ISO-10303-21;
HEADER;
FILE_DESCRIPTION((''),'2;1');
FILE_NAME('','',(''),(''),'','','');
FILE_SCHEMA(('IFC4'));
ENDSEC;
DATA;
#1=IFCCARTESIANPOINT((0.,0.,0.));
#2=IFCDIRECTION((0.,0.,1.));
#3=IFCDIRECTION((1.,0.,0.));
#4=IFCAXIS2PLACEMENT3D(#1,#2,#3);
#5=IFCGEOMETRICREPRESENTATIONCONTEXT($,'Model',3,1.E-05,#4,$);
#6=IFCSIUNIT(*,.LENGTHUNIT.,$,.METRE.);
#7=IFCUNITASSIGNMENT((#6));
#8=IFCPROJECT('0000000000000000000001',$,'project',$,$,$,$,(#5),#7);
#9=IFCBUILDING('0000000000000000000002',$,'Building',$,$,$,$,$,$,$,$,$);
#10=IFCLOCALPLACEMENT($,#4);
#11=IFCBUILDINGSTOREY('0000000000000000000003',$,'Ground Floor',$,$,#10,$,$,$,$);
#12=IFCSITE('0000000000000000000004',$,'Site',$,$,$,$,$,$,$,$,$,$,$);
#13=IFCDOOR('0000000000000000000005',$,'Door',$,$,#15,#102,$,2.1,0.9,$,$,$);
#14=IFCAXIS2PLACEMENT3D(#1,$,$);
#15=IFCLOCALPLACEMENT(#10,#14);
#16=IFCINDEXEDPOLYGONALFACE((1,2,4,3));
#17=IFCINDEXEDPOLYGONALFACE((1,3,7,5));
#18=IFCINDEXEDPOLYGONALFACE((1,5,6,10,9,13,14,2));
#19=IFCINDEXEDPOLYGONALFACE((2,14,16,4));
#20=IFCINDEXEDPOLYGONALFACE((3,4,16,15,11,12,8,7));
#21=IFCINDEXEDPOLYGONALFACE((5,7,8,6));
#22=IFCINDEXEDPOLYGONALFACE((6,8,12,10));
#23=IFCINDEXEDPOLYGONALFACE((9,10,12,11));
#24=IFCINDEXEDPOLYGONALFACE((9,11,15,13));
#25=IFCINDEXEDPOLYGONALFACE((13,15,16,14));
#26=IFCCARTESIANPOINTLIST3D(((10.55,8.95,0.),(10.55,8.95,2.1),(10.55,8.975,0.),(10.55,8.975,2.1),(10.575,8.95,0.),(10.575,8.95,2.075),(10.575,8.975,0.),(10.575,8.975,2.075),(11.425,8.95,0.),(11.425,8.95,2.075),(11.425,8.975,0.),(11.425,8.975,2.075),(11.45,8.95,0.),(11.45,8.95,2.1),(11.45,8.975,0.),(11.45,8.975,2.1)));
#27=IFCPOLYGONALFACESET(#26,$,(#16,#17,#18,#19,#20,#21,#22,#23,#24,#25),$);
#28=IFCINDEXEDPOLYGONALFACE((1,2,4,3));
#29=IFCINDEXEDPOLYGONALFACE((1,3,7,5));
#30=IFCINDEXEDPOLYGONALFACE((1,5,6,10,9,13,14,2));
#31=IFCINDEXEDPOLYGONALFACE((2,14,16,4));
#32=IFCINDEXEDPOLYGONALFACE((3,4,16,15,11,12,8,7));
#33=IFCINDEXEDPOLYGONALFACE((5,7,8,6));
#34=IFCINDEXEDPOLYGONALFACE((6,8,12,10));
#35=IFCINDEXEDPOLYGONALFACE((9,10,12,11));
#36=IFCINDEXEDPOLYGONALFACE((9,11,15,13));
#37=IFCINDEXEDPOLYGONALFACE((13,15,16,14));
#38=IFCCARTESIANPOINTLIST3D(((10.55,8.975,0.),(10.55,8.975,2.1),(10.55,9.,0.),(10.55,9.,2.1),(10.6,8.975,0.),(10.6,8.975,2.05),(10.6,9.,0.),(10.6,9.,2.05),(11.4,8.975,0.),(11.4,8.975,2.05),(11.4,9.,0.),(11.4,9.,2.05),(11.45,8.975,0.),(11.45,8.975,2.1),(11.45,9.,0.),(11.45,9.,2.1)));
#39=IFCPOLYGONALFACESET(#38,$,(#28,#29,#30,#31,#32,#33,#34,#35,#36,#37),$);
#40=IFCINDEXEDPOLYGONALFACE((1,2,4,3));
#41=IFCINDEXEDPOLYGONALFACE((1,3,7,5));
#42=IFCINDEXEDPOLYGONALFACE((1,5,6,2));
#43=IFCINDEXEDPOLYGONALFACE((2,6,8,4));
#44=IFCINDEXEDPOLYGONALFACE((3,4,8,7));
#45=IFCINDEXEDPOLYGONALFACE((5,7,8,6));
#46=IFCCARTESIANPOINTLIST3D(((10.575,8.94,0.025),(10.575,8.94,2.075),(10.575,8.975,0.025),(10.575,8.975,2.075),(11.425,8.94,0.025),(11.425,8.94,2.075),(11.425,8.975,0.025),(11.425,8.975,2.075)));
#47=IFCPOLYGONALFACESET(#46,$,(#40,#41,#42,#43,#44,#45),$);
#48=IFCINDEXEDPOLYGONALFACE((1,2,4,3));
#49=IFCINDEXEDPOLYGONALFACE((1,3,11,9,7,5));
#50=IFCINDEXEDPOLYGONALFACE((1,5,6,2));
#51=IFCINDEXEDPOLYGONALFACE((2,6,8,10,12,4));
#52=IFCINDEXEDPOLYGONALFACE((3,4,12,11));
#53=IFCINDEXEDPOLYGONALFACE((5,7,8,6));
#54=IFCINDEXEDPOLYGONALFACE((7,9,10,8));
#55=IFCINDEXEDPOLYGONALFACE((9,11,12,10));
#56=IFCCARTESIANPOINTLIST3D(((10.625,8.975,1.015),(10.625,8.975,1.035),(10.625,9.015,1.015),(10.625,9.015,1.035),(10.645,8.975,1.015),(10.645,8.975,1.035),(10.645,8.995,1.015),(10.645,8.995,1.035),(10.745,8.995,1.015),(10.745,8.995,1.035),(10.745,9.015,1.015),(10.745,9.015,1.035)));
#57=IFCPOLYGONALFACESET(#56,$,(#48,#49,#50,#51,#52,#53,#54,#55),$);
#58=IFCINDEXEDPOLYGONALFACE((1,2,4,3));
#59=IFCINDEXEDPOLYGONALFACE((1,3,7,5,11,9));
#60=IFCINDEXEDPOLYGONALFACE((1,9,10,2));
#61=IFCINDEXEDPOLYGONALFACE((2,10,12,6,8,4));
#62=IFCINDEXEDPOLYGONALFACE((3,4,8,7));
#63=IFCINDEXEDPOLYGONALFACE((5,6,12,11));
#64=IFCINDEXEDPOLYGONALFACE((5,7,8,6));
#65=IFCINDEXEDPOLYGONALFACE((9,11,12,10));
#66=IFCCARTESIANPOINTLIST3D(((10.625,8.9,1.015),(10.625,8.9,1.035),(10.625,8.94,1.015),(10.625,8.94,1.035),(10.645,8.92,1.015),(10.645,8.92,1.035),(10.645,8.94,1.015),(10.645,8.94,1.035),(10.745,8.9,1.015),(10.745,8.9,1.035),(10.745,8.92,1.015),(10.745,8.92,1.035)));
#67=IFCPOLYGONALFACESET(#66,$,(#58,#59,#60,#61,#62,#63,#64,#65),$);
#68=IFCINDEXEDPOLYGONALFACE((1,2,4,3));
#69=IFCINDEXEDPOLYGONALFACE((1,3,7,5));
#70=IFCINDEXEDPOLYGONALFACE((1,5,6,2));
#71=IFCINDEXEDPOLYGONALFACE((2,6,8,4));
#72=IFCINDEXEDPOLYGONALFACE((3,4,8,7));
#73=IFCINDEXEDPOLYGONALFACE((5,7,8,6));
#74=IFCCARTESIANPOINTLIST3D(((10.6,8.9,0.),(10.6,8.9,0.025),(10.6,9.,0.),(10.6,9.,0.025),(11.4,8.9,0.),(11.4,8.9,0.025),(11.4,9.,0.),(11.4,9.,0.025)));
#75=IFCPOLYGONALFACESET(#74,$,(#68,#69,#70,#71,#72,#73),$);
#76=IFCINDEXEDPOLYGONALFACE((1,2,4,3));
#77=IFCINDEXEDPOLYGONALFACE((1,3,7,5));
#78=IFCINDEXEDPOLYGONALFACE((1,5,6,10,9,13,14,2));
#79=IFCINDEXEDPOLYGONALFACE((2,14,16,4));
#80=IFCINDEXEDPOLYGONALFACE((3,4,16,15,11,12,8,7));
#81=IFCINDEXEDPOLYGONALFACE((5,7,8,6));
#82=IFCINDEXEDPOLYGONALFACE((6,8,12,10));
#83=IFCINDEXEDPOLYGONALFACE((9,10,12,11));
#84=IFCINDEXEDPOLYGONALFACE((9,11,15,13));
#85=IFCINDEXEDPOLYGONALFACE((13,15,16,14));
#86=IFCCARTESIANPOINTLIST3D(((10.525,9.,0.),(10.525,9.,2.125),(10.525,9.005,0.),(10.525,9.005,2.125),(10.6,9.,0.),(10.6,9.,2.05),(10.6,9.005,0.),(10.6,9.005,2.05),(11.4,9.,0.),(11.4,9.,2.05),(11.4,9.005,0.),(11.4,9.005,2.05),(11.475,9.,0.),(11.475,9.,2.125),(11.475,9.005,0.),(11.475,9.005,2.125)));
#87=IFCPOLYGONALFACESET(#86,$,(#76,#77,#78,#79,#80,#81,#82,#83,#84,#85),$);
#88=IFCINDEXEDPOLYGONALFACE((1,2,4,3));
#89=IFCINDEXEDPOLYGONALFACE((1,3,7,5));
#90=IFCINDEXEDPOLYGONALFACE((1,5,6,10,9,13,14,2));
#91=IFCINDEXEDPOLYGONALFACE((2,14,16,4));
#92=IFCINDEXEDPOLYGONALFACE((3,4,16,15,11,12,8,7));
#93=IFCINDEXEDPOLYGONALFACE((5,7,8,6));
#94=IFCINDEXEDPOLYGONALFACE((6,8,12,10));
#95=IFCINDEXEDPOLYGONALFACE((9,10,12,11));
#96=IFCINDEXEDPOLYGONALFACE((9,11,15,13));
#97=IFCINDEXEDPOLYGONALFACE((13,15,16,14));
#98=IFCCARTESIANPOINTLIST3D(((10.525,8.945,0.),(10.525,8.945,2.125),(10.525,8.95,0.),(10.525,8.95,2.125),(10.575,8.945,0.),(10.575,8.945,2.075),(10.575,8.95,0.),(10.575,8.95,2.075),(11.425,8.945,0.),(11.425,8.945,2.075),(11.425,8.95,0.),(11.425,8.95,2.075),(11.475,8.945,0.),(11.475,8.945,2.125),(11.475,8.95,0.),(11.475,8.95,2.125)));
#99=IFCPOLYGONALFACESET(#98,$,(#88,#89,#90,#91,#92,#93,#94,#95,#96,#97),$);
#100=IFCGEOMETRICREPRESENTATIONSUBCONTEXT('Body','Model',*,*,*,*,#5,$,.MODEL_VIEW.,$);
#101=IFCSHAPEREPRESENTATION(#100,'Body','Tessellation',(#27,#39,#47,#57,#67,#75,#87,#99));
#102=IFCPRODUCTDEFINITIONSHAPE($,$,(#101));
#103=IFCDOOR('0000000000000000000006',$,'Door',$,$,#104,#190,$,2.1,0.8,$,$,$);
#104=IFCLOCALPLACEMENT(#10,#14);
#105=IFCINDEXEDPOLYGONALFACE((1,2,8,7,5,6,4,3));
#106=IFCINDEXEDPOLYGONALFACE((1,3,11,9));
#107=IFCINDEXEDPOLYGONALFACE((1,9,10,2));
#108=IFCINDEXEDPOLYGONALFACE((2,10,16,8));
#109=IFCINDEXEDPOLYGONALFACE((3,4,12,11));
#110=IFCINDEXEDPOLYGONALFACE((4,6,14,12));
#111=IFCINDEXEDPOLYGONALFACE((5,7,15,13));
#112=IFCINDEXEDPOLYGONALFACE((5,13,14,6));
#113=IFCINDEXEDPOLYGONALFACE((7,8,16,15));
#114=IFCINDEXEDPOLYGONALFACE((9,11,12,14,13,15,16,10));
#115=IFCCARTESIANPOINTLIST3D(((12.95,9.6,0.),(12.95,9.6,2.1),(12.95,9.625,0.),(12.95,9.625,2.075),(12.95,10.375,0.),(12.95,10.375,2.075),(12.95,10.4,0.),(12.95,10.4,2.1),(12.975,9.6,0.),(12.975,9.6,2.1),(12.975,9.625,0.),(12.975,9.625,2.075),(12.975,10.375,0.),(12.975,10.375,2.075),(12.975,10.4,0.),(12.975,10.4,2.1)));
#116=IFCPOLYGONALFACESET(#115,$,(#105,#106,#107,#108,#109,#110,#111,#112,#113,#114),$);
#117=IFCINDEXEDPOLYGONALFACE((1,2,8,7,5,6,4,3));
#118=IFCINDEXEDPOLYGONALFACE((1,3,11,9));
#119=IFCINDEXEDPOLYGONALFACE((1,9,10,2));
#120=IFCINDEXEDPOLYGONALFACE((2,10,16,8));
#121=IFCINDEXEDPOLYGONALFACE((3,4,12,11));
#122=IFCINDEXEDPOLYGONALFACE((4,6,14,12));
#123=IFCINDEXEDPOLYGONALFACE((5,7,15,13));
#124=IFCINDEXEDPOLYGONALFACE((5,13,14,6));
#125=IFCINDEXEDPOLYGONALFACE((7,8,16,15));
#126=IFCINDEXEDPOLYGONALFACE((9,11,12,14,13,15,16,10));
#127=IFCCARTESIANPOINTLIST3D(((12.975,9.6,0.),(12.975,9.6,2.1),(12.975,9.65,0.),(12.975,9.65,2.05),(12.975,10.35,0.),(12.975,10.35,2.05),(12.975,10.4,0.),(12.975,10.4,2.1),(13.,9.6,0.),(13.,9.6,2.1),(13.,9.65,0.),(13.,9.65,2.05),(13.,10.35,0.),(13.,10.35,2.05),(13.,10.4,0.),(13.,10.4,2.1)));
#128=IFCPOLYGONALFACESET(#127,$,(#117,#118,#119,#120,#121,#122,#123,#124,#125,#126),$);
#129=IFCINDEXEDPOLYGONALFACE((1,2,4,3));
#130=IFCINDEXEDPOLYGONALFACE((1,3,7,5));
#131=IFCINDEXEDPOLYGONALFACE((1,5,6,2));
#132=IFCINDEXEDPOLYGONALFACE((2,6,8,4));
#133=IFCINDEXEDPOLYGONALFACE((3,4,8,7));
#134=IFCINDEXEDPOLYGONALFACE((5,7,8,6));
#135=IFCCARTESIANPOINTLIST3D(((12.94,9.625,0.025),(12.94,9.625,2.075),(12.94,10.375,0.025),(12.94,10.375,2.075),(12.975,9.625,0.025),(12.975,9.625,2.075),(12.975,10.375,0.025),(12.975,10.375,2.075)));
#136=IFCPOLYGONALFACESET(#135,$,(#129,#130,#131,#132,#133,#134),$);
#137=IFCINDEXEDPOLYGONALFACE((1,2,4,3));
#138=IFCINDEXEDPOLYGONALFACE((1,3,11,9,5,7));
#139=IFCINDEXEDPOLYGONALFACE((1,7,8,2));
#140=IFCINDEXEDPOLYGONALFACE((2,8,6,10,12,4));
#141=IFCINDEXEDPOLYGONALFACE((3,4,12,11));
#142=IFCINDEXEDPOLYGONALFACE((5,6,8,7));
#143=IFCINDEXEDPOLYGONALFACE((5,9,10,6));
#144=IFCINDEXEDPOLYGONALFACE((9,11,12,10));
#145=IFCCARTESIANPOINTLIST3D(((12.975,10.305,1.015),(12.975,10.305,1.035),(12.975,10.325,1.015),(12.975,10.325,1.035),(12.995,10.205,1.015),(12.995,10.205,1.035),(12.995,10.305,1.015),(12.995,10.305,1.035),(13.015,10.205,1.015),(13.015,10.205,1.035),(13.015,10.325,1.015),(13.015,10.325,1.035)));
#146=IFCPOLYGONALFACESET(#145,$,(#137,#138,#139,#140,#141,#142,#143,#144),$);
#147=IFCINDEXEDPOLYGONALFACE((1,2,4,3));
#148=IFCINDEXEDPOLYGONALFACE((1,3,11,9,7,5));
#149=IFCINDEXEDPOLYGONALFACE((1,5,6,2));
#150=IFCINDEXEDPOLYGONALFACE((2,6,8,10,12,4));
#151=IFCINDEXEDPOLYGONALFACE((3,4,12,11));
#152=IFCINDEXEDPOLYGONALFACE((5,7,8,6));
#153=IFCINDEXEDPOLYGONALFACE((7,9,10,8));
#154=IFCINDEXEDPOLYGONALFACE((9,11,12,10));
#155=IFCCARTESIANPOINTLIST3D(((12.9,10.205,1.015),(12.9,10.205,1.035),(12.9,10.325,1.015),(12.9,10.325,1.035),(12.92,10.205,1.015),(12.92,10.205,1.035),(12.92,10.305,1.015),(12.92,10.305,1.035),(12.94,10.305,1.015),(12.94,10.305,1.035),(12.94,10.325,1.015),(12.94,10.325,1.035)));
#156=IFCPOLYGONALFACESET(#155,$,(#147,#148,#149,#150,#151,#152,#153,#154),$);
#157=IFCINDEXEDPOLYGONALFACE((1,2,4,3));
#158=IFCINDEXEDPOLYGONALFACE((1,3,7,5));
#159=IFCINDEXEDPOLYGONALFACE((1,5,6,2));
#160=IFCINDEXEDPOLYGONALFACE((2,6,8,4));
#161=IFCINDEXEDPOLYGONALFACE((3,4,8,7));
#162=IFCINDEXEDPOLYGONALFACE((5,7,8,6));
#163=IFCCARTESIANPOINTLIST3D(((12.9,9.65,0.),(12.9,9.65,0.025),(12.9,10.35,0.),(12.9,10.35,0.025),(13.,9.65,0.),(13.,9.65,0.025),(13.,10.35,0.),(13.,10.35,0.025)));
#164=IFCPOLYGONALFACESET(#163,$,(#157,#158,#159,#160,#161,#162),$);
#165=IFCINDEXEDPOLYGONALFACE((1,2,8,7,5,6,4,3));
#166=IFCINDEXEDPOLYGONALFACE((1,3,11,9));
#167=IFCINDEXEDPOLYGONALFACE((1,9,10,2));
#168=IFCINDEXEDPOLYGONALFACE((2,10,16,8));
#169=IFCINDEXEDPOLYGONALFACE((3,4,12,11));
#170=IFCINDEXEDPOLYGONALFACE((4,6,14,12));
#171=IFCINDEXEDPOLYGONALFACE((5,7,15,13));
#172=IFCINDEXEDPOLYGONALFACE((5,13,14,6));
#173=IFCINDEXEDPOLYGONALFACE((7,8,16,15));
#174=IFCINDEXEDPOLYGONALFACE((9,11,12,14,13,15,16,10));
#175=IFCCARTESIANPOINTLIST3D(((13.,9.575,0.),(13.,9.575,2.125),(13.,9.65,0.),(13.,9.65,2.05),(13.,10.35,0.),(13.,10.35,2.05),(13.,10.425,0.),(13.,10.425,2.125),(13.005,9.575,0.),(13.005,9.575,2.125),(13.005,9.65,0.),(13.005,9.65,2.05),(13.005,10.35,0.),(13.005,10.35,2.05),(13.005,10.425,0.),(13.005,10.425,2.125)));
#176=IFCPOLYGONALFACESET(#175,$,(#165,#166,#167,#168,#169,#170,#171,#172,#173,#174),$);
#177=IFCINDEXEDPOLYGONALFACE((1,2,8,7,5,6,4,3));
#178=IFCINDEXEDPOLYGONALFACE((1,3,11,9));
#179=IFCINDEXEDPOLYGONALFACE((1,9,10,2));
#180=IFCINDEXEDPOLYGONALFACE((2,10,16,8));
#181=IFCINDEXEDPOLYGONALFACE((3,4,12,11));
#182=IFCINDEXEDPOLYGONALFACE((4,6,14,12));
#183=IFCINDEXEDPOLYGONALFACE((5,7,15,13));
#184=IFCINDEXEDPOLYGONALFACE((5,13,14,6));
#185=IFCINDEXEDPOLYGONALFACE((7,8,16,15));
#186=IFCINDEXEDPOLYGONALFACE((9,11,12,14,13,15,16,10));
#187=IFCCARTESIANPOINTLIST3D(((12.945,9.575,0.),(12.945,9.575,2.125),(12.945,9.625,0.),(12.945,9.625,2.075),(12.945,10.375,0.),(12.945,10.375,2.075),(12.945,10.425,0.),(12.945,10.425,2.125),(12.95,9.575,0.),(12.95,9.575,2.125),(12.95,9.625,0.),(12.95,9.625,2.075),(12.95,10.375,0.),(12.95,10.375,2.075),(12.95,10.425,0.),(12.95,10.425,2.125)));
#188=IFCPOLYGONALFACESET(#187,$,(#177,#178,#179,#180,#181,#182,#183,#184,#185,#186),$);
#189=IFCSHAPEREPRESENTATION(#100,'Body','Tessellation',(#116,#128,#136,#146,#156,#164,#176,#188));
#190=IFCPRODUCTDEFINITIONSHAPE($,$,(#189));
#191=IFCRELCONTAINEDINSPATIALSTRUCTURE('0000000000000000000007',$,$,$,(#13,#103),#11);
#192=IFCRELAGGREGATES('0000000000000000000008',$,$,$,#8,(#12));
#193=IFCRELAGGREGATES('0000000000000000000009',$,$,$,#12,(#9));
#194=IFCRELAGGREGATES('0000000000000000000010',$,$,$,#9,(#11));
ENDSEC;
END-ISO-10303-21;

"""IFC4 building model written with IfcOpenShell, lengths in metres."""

from ifc_helpers import new_model, si_unit, frame, origin_with_axes, place, context, subcontext, project, spatial, line, indexed_curve, outline, extrude, element, save


model = new_model("IFC4")

# Units and contexts
model_context = context("Model", 3, precision=1e-05, world=origin_with_axes())
body_context = subcontext(model_context, "Body", "Model", "MODEL_VIEW")
ifc_project = project(units=[si_unit("LENGTHUNIT", "METRE")], contexts=[model_context])

# Site, building, storey
site = spatial("IfcSite", under=ifc_project, Name="Site")
building = spatial("IfcBuilding", under=site, Name="Building")
storey_placement = place(None, origin_with_axes())
storey = spatial("IfcBuildingStorey", under=building, at=storey_placement, Name="Ground Floor")

# Doors
door_1_placement = place(storey_placement, frame((11.45, 9.0, 0.0), z_axis=(0.0, 0.0, 1.0), x_axis=(-1.0, 0.0, 0.0)))
element("IfcDoor", 1, at=door_1_placement, inside=storey, Name="Door", OverallHeight=2.1, OverallWidth=0.9, context=body_context, shape_type="SweptSolid", body=[
    extrude(outline(indexed_curve([(0.0, 0.0), (0.0, 2.1), (0.9, 2.1), (0.9, 0.0), (0.875, 0.0), (0.875, 2.075), (0.025, 2.075), (0.025, 0.0)], segments=[line(1, 2, 3, 4, 5, 6, 7, 8, 1)])), frame((0.0, 0.025, 0.0), z_axis=(0.0, -1.0, 0.0), x_axis=(1.0, 0.0, 0.0)), (0.0, 0.0, -1.0), 0.025),
    extrude(outline(indexed_curve([(0.0, 0.0), (0.0, 2.1), (0.9, 2.1), (0.9, 0.0), (0.85, 0.0), (0.85, 2.05), (0.05, 2.05), (0.05, 0.0)], segments=[line(1, 2, 3, 4, 5, 6, 7, 8, 1)])), frame((0.0, 0.0, 0.0), z_axis=(0.0, -1.0, 0.0), x_axis=(1.0, 0.0, 0.0)), (0.0, 0.0, -1.0), 0.025),
    extrude(outline(indexed_curve([(0.0, 0.0), (0.85, 0.0), (0.85, 0.035), (0.0, 0.035)], segments=[line(1, 2, 3, 4, 1)])), frame((0.025, 0.025, 0.025), z_axis=(0.0, 0.0, 1.0), x_axis=(1.0, 0.0, 0.0)), (0.0, 0.0, 1.0), 2.05),
    extrude(outline(indexed_curve([(0.0, 0.0), (0.0, -0.04), (-0.12, -0.04), (-0.12, -0.02), (-0.02, -0.02), (-0.02, 0.0)], segments=[line(1, 2, 3, 4, 5, 6, 1)])), frame((0.825, 0.025, 1.015), z_axis=(0.0, 0.0, 1.0), x_axis=(1.0, 0.0, 0.0)), (0.0, 0.0, 1.0), 0.02),
    extrude(outline(indexed_curve([(0.0, 0.0), (0.0, 0.04), (-0.12, 0.04), (-0.12, 0.02), (-0.02, 0.02), (-0.02, 0.0)], segments=[line(1, 2, 3, 4, 5, 6, 1)])), frame((0.825, 0.06, 1.015), z_axis=(0.0, 0.0, 1.0), x_axis=(1.0, 0.0, 0.0)), (0.0, 0.0, 1.0), 0.02),
    extrude(outline(indexed_curve([(0.0, 0.0), (0.8, 0.0), (0.8, 0.1), (0.0, 0.1)], segments=[line(1, 2, 3, 4, 1)])), frame((0.05, 0.0, 0.0), z_axis=(0.0, 0.0, 1.0), x_axis=(1.0, 0.0, 0.0)), (0.0, 0.0, 1.0), 0.025),
    extrude(outline(indexed_curve([(0.0, 0.0), (0.0, 2.125), (0.95, 2.125), (0.95, 0.0), (0.875, 0.0), (0.875, 2.05), (0.075, 2.05), (0.075, 0.0)], segments=[line(1, 2, 3, 4, 5, 6, 7, 8, 1)])), frame((-0.025, -0.005, 0.0), z_axis=(0.0, -1.0, 0.0), x_axis=(1.0, 0.0, 0.0)), (0.0, 0.0, -1.0), 0.005),
    extrude(outline(indexed_curve([(0.0, 0.0), (0.0, 2.125), (0.95, 2.125), (0.95, 0.0), (0.9, 0.0), (0.9, 2.075), (0.05, 2.075), (0.05, 0.0)], segments=[line(1, 2, 3, 4, 5, 6, 7, 8, 1)])), frame((-0.025, 0.05, 0.0), z_axis=(0.0, -1.0, 0.0), x_axis=(1.0, 0.0, 0.0)), (0.0, 0.0, -1.0), 0.005),
])
door_2_placement = place(storey_placement, frame((13.0, 9.6, 0.0), z_axis=(0.0, 0.0, 1.0), x_axis=(0.0, 1.0, 0.0)))
element("IfcDoor", 2, at=door_2_placement, inside=storey, Name="Door", OverallHeight=2.1, OverallWidth=0.8, context=body_context, shape_type="SweptSolid", body=[
    extrude(outline(indexed_curve([(0.0, 0.0), (0.0, 2.1), (0.8, 2.1), (0.8, 0.0), (0.775, 0.0), (0.775, 2.075), (0.025, 2.075), (0.025, 0.0)], segments=[line(1, 2, 3, 4, 5, 6, 7, 8, 1)])), frame((0.0, 0.025, 0.0), z_axis=(0.0, -1.0, 0.0), x_axis=(1.0, 0.0, 0.0)), (0.0, 0.0, -1.0), 0.025),
    extrude(outline(indexed_curve([(0.0, 0.0), (0.0, 2.1), (0.8, 2.1), (0.8, 0.0), (0.75, 0.0), (0.75, 2.05), (0.05, 2.05), (0.05, 0.0)], segments=[line(1, 2, 3, 4, 5, 6, 7, 8, 1)])), frame((0.0, 0.0, 0.0), z_axis=(0.0, -1.0, 0.0), x_axis=(1.0, 0.0, 0.0)), (0.0, 0.0, -1.0), 0.025),
    extrude(outline(indexed_curve([(0.0, 0.0), (0.75, 0.0), (0.75, 0.035), (0.0, 0.035)], segments=[line(1, 2, 3, 4, 1)])), frame((0.025, 0.025, 0.025), z_axis=(0.0, 0.0, 1.0), x_axis=(1.0, 0.0, 0.0)), (0.0, 0.0, 1.0), 2.05),
    extrude(outline(indexed_curve([(0.0, 0.0), (0.0, -0.04), (-0.12, -0.04), (-0.12, -0.02), (-0.02, -0.02), (-0.02, 0.0)], segments=[line(1, 2, 3, 4, 5, 6, 1)])), frame((0.725, 0.025, 1.015), z_axis=(0.0, 0.0, 1.0), x_axis=(1.0, 0.0, 0.0)), (0.0, 0.0, 1.0), 0.02),
    extrude(outline(indexed_curve([(0.0, 0.0), (0.0, 0.04), (-0.12, 0.04), (-0.12, 0.02), (-0.02, 0.02), (-0.02, 0.0)], segments=[line(1, 2, 3, 4, 5, 6, 1)])), frame((0.725, 0.06, 1.015), z_axis=(0.0, 0.0, 1.0), x_axis=(1.0, 0.0, 0.0)), (0.0, 0.0, 1.0), 0.02),
    extrude(outline(indexed_curve([(0.0, 0.0), (0.7, 0.0), (0.7, 0.1), (0.0, 0.1)], segments=[line(1, 2, 3, 4, 1)])), frame((0.05, 0.0, 0.0), z_axis=(0.0, 0.0, 1.0), x_axis=(1.0, 0.0, 0.0)), (0.0, 0.0, 1.0), 0.025),
    extrude(outline(indexed_curve([(0.0, 0.0), (0.0, 2.125), (0.85, 2.125), (0.85, 0.0), (0.775, 0.0), (0.775, 2.05), (0.075, 2.05), (0.075, 0.0)], segments=[line(1, 2, 3, 4, 5, 6, 7, 8, 1)])), frame((-0.025, -0.005, 0.0), z_axis=(0.0, -1.0, 0.0), x_axis=(1.0, 0.0, 0.0)), (0.0, 0.0, -1.0), 0.005),
    extrude(outline(indexed_curve([(0.0, 0.0), (0.0, 2.125), (0.85, 2.125), (0.85, 0.0), (0.8, 0.0), (0.8, 2.075), (0.05, 2.075), (0.05, 0.0)], segments=[line(1, 2, 3, 4, 5, 6, 7, 8, 1)])), frame((-0.025, 0.05, 0.0), z_axis=(0.0, -1.0, 0.0), x_axis=(1.0, 0.0, 0.0)), (0.0, 0.0, -1.0), 0.005),
])

save(model, "model.ifc")
